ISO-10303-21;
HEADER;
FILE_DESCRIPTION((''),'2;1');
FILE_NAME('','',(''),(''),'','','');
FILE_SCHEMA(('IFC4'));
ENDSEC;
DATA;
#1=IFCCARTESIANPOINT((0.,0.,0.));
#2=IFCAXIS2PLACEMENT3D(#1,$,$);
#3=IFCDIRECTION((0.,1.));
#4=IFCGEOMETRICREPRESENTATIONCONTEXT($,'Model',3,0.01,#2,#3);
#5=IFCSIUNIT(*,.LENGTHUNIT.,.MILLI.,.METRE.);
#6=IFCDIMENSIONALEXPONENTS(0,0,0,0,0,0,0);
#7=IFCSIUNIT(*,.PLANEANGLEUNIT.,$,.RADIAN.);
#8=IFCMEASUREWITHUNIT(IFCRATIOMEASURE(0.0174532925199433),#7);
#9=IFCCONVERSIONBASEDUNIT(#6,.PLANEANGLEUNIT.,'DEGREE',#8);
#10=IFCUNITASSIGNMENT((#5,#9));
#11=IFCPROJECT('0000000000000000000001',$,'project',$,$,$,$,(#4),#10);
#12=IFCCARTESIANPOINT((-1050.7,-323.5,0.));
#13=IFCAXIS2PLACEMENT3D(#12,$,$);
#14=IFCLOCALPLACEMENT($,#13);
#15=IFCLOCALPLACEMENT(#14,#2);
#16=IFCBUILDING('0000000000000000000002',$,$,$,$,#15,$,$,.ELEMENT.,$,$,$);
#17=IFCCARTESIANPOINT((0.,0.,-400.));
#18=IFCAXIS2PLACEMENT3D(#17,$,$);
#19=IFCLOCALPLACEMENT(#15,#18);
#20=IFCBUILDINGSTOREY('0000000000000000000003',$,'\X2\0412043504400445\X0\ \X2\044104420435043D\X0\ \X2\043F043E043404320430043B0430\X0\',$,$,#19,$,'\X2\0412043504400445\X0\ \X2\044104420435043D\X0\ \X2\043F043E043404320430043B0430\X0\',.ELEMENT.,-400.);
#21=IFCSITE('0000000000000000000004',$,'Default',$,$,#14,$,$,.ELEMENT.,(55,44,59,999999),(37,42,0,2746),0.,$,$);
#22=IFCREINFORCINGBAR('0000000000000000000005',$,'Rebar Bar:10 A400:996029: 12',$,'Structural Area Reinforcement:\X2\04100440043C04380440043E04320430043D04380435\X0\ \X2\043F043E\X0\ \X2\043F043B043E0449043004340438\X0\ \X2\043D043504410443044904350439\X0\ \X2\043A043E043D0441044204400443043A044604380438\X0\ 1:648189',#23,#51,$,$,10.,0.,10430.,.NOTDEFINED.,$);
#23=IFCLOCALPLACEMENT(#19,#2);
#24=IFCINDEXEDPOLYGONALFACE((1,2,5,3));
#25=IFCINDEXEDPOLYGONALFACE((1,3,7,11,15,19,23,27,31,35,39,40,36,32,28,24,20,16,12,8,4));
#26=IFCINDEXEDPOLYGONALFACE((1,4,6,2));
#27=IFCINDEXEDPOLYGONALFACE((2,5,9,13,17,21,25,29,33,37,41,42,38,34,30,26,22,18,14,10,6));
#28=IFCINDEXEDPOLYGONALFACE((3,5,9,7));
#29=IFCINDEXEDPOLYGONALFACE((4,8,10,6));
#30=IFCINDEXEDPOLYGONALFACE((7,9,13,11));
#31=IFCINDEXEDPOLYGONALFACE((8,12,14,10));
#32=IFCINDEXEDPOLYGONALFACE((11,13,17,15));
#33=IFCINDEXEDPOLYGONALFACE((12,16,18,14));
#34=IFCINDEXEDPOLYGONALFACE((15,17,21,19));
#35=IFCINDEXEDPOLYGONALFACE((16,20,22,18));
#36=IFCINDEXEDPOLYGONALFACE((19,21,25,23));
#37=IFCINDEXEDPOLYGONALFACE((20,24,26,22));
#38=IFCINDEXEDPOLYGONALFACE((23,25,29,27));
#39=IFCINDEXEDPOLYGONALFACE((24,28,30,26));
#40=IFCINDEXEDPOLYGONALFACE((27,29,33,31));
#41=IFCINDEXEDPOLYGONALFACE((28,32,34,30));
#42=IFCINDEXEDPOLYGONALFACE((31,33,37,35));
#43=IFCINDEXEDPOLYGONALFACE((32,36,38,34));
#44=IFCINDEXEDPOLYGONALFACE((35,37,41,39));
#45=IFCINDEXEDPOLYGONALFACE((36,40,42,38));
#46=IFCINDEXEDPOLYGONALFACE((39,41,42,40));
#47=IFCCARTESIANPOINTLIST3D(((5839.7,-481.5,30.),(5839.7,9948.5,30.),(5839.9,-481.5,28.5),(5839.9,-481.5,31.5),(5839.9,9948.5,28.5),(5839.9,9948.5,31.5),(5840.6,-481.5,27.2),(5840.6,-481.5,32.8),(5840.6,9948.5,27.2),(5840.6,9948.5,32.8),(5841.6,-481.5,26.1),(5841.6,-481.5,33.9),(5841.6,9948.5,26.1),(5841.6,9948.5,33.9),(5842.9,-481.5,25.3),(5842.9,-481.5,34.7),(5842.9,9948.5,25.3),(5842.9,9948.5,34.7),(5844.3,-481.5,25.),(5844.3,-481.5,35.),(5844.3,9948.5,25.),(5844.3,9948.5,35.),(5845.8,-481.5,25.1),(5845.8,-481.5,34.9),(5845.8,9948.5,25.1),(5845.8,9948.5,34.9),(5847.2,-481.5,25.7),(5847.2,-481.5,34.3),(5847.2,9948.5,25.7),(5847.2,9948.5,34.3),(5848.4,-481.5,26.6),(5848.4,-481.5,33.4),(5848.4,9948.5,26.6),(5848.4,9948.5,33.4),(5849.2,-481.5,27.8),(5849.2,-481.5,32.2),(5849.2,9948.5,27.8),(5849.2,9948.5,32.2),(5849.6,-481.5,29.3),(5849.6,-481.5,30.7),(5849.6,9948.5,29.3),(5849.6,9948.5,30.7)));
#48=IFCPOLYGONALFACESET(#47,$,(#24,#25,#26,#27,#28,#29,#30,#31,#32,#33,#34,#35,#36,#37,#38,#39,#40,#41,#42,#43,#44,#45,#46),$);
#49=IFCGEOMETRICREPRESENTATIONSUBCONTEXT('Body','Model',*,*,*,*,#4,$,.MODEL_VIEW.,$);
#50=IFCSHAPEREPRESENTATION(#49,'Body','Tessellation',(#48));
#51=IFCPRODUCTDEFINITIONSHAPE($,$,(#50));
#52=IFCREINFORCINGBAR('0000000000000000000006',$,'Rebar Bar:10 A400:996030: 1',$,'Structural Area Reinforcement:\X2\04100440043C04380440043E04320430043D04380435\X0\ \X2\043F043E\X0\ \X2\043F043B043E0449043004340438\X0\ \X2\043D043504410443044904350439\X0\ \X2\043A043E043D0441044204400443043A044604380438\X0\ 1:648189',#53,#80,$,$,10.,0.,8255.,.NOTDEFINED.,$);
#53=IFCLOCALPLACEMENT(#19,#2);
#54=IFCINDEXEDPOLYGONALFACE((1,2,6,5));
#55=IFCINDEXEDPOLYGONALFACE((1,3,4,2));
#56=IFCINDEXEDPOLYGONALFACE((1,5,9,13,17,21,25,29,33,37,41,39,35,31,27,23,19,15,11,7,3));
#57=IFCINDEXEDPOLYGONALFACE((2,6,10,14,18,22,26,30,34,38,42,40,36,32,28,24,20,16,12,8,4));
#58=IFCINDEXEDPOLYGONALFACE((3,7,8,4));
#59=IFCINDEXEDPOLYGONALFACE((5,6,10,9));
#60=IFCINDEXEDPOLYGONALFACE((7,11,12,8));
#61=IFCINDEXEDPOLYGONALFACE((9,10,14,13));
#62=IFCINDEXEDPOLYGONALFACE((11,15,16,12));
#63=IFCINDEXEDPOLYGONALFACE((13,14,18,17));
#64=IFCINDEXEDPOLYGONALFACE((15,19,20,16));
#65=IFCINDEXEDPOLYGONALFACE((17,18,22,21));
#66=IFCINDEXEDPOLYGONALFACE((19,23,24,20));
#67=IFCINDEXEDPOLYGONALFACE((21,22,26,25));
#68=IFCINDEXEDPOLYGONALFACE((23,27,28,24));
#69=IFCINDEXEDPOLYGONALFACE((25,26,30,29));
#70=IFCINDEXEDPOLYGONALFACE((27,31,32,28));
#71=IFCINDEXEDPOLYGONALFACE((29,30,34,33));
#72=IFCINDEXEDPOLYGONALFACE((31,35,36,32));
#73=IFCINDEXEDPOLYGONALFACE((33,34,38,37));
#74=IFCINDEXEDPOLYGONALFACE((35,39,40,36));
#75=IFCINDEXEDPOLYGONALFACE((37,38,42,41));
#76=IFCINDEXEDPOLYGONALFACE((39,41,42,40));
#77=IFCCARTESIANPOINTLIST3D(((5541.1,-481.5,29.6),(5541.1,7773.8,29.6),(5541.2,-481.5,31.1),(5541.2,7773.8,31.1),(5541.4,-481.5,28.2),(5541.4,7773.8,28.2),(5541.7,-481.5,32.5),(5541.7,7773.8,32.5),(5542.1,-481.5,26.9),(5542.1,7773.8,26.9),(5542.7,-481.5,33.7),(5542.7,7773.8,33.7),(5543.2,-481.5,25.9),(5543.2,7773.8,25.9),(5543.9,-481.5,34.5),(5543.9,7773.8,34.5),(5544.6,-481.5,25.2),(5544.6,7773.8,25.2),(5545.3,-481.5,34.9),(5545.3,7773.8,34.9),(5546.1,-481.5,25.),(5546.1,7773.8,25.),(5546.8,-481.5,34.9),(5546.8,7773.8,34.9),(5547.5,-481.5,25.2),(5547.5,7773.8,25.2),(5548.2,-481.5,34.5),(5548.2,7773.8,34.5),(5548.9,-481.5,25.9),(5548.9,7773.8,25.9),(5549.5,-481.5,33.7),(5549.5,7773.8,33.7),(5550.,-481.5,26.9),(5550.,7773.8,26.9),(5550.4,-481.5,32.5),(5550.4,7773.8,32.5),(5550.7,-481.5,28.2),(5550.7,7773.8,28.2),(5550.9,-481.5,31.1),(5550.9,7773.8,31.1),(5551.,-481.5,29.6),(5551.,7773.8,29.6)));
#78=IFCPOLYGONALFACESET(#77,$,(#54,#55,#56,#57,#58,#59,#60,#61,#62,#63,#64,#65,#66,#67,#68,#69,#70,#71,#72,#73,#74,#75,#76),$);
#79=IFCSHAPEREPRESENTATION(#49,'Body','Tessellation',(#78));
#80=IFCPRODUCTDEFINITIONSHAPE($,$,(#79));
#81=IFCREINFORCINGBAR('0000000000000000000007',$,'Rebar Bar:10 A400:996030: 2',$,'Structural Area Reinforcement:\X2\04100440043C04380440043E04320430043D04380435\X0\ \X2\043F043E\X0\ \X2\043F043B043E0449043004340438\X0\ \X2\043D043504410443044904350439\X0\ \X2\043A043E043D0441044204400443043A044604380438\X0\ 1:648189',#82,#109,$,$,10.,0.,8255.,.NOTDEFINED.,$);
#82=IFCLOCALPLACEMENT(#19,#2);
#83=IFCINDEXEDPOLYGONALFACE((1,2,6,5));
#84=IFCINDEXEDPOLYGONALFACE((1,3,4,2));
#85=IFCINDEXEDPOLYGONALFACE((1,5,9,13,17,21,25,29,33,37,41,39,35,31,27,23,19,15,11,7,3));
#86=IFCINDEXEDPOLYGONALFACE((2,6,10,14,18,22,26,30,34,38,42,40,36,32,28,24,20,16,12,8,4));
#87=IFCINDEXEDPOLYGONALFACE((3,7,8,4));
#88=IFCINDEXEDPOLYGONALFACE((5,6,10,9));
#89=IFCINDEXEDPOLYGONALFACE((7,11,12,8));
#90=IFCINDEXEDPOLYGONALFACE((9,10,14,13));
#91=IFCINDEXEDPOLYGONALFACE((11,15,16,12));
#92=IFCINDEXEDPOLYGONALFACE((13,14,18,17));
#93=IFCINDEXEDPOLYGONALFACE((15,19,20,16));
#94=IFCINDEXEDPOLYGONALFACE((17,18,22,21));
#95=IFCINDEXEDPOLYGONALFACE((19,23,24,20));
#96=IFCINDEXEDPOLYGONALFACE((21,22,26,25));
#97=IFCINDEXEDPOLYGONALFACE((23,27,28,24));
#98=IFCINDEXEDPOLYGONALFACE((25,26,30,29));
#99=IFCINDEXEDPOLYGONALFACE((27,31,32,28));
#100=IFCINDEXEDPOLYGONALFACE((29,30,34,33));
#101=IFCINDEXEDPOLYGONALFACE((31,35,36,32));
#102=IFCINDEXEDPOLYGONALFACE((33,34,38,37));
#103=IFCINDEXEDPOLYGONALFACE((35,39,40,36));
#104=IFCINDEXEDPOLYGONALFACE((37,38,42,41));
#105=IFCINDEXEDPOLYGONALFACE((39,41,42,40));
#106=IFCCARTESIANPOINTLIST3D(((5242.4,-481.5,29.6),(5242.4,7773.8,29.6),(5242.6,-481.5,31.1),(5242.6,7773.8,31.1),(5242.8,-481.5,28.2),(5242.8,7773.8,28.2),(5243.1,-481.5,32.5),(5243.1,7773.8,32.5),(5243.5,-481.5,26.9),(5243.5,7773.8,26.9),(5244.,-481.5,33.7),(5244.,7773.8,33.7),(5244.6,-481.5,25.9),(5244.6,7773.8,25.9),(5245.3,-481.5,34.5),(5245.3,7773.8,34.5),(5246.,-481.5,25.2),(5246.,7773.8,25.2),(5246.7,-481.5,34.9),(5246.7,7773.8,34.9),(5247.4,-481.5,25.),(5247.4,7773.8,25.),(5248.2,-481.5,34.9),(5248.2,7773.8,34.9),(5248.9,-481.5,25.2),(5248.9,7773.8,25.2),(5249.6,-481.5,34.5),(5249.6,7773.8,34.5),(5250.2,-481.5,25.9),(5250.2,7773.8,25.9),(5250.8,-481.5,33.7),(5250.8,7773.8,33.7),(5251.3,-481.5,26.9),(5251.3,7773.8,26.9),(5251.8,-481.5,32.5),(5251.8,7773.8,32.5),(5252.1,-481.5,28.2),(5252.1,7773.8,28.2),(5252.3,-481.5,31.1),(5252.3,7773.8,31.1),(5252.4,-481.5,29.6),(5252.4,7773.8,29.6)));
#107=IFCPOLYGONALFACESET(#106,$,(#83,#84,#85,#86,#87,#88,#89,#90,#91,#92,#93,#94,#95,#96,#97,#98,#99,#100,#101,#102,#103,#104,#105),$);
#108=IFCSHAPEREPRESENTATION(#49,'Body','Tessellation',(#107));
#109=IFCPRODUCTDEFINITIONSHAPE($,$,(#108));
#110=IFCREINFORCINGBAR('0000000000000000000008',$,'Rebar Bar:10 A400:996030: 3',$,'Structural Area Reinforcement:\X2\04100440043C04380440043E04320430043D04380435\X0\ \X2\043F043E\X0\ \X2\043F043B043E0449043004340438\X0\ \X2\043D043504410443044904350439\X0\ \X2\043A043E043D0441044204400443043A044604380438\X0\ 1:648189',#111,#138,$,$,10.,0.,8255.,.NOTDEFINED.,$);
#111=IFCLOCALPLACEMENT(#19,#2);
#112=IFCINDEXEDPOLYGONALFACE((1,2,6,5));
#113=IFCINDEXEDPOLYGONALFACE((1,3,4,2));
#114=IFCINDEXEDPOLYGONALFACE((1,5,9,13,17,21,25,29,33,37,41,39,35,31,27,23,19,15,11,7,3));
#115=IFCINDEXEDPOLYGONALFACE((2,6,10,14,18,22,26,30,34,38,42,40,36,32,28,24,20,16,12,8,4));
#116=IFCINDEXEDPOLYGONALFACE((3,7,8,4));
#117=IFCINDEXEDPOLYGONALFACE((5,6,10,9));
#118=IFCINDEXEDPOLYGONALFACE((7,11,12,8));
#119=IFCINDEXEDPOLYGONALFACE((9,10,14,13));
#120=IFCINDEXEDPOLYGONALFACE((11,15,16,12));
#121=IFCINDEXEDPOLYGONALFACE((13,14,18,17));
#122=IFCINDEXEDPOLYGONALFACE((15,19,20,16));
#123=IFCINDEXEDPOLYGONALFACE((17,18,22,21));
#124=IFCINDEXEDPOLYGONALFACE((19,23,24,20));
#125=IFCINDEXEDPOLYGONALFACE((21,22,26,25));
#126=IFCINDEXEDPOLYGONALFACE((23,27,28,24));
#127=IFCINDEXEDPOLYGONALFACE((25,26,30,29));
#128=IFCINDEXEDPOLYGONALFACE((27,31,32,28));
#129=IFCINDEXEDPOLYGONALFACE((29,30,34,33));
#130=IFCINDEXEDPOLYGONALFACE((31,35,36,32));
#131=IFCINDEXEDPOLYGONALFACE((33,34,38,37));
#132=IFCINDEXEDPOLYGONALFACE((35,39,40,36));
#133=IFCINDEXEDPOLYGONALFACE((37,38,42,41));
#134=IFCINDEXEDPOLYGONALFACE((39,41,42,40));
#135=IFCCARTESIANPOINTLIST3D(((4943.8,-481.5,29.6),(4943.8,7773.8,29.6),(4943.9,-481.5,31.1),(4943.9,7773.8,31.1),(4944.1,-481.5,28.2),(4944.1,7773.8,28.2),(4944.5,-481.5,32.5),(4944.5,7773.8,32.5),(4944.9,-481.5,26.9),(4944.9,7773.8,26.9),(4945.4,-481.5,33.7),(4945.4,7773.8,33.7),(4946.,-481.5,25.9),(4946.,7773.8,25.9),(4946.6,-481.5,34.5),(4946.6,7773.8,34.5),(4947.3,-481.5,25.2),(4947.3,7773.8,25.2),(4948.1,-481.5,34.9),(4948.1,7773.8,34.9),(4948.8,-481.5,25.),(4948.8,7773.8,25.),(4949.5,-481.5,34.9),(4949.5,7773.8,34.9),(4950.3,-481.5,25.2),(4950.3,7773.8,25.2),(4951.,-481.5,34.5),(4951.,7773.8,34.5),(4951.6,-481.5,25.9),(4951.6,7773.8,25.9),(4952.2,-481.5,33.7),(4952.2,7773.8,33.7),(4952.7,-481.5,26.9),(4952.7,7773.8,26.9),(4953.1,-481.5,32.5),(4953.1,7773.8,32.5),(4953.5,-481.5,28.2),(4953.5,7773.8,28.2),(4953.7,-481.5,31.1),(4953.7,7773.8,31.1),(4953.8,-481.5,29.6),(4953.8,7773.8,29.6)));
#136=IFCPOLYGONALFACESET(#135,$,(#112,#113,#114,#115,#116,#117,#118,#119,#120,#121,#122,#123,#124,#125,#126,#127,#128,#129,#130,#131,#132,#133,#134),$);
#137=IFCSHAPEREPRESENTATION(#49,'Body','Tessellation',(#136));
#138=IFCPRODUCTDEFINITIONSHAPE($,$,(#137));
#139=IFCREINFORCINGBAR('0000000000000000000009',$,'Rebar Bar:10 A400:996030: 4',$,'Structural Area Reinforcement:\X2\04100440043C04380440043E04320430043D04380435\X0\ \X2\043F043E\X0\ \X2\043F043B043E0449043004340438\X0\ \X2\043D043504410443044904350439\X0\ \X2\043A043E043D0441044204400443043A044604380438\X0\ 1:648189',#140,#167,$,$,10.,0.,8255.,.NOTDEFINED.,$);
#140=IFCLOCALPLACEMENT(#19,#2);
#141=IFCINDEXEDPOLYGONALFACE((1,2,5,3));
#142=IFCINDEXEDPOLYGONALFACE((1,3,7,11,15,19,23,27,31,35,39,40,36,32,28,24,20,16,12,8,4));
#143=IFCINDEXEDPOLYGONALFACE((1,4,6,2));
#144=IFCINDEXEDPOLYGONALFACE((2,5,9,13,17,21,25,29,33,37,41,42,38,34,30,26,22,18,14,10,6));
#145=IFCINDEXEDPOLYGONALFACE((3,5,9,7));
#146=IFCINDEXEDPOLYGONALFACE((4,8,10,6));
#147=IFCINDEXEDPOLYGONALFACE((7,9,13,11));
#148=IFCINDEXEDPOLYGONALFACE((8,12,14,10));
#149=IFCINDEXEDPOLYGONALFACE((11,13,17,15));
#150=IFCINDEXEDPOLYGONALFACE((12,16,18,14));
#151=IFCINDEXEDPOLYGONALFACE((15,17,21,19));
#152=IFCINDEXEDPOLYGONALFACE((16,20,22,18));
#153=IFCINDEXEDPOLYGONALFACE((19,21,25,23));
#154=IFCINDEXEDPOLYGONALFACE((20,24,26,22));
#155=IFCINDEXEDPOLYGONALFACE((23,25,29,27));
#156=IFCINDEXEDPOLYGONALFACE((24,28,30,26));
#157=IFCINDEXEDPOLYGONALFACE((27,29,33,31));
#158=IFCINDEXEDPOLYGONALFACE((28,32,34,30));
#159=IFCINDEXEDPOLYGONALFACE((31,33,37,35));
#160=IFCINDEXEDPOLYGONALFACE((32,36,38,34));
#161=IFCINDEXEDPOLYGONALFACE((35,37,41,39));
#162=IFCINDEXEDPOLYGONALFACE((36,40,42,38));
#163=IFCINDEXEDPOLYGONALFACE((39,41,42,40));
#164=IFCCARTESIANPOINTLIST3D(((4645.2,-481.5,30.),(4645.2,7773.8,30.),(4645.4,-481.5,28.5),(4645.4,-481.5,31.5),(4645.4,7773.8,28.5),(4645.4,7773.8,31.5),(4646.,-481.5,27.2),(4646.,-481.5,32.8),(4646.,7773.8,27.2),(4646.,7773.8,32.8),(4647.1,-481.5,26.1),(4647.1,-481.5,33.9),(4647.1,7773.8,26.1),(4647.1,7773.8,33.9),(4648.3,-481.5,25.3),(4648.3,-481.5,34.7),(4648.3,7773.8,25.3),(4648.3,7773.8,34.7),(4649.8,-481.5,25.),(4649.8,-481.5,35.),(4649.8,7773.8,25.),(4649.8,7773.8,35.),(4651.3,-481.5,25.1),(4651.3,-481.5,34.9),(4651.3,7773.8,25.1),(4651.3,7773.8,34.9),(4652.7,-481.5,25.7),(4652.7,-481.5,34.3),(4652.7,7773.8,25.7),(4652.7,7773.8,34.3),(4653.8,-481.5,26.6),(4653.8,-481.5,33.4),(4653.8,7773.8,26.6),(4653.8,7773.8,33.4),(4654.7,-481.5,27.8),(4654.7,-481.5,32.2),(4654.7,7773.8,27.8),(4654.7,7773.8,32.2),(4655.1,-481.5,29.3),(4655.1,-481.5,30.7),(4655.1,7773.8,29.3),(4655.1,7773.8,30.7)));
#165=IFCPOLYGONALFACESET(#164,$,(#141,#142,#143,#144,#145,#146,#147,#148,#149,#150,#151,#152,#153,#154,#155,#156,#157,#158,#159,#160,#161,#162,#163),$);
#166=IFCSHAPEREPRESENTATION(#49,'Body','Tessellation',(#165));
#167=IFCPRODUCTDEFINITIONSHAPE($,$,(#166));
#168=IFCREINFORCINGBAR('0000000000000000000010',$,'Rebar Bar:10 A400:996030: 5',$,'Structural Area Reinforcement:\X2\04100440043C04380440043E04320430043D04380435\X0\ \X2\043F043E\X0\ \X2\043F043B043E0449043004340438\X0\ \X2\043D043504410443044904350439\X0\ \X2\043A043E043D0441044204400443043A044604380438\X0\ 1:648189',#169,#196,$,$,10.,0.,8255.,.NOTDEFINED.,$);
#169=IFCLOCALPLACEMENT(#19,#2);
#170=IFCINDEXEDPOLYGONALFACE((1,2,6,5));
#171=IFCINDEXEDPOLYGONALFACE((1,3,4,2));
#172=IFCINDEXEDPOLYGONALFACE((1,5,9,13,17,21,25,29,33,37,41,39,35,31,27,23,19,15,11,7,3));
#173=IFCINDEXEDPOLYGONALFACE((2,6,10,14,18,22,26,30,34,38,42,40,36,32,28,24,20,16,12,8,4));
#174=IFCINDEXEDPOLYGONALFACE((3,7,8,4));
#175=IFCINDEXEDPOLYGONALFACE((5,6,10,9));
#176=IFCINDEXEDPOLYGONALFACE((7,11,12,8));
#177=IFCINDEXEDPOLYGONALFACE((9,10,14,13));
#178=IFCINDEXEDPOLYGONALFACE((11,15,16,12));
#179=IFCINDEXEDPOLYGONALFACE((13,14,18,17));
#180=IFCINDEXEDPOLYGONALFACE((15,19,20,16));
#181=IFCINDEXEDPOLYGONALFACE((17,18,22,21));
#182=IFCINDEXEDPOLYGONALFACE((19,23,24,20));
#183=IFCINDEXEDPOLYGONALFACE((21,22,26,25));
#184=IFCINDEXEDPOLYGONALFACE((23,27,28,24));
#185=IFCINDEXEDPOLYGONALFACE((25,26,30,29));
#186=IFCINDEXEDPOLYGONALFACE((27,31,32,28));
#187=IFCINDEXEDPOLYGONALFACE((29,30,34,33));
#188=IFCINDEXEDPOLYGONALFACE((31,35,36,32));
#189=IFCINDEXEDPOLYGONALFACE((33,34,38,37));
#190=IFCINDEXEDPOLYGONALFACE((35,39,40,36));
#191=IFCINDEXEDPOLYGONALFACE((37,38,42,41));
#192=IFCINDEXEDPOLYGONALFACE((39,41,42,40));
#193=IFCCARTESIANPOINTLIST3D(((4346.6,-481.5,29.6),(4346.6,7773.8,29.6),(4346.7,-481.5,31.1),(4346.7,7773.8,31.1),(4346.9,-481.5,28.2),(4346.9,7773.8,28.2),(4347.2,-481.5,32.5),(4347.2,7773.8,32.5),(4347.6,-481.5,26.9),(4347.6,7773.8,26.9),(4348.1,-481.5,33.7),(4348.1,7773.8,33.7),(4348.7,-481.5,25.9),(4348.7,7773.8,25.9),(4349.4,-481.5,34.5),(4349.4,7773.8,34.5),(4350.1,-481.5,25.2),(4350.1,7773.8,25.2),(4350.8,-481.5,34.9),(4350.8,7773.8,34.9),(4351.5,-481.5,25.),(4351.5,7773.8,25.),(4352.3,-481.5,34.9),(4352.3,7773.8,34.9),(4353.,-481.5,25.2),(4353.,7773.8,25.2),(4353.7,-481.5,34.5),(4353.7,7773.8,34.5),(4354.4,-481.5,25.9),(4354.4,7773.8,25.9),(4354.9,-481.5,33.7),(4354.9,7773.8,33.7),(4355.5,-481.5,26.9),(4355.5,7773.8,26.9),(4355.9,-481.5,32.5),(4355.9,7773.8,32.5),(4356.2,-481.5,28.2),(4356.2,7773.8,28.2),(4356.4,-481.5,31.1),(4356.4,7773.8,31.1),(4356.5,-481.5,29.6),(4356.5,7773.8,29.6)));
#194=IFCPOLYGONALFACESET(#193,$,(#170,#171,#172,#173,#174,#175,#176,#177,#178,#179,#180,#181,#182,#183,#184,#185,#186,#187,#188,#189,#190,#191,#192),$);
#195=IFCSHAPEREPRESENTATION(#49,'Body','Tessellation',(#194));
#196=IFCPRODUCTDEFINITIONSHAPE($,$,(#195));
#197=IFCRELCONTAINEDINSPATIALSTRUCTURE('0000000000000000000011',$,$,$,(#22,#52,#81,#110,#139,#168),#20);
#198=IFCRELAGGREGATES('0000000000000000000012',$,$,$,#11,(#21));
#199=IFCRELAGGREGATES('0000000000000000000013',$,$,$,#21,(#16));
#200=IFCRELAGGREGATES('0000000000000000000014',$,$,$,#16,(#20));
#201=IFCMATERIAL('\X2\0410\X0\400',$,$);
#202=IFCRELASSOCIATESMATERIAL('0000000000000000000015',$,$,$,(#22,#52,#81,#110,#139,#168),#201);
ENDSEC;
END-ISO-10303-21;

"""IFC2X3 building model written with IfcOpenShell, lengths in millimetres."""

from ifc_helpers import new_model, entity, si_unit, converted_unit, direction, frame, origin, place, context, subcontext, project, spatial, material, element, save


model = new_model("IFC2X3")

# Units and contexts
model_context = context("Model", 3, precision=0.01, world=origin(), true_north=direction((0.0, 1.0)))
body_context = subcontext(model_context, "Body", "Model", "MODEL_VIEW")
ifc_project = project(units=[si_unit("LENGTHUNIT", "METRE", prefix="MILLI"), converted_unit("PLANEANGLEUNIT", "DEGREE", entity("IfcRatioMeasure", 0.0174532925199433), si_unit("PLANEANGLEUNIT", "RADIAN"), dimensions=[0, 0, 0, 0, 0, 0, 0])], contexts=[model_context])

# Site, building, storey
site_placement = place(None, frame((-1050.7, -323.5, 0.0)))
site = spatial("IfcSite", under=ifc_project, at=site_placement, Name="Default", CompositionType="ELEMENT", RefLatitude=(55, 44, 59, 999999), RefLongitude=(37, 42, 0, 2746), RefElevation=0.0)
building_placement = place(site_placement, origin())
building = spatial("IfcBuilding", under=site, at=building_placement, CompositionType="ELEMENT")
storey_placement = place(building_placement, frame((0.0, 0.0, -400.0)))
storey = spatial("IfcBuildingStorey", under=building, at=storey_placement, Name="Верх стен подвала", LongName="Верх стен подвала", CompositionType="ELEMENT", Elevation=-400.0)

# Reinforcing bars
ifc_material = material(Name="А400")
reinforcing_bar_1_placement = place(storey_placement, origin())
element("IfcReinforcingBar", 1, at=reinforcing_bar_1_placement, inside=storey, material=ifc_material, Name="Rebar Bar:10 A400:996029: 12", ObjectType="Structural Area Reinforcement:Армирование по площади несущей конструкции 1:648189", BarLength=10430.0, BarRole="NOTDEFINED", CrossSectionArea=0.0, NominalDiameter=10.0, context=body_context, shape_type="AdvancedSweptSolid", body=[
    entity("IfcSweptDiskSolid", entity("IfcCompositeCurve", [entity("IfcCompositeCurveSegment", "CONTINUOUS", True, entity("IfcPolyline", [entity("IfcCartesianPoint", [5844.7, 9948.5, 30.0]), entity("IfcCartesianPoint", [5844.7, -481.5, 30.0])]))], False), 5.0, None, 0.0, 1.0),
])
reinforcing_bar_2_placement = place(storey_placement, origin())
element("IfcReinforcingBar", 2, at=reinforcing_bar_2_placement, inside=storey, material=ifc_material, Name="Rebar Bar:10 A400:996030: 1", ObjectType="Structural Area Reinforcement:Армирование по площади несущей конструкции 1:648189", BarLength=8255.0, BarRole="NOTDEFINED", CrossSectionArea=0.0, NominalDiameter=10.0, context=body_context, shape_type="AdvancedSweptSolid", body=[
    entity("IfcSweptDiskSolid", entity("IfcCompositeCurve", [entity("IfcCompositeCurveSegment", "CONTINUOUS", True, entity("IfcPolyline", [entity("IfcCartesianPoint", [5546.1, 7773.8, 30.0]), entity("IfcCartesianPoint", [5546.1, -481.5, 30.0])]))], False), 5.0, None, 0.0, 1.0),
])
reinforcing_bar_3_placement = place(storey_placement, origin())
element("IfcReinforcingBar", 3, at=reinforcing_bar_3_placement, inside=storey, material=ifc_material, Name="Rebar Bar:10 A400:996030: 2", ObjectType="Structural Area Reinforcement:Армирование по площади несущей конструкции 1:648189", BarLength=8255.0, BarRole="NOTDEFINED", CrossSectionArea=0.0, NominalDiameter=10.0, context=body_context, shape_type="AdvancedSweptSolid", body=[
    entity("IfcSweptDiskSolid", entity("IfcCompositeCurve", [entity("IfcCompositeCurveSegment", "CONTINUOUS", True, entity("IfcPolyline", [entity("IfcCartesianPoint", [5247.4, 7773.8, 30.0]), entity("IfcCartesianPoint", [5247.4, -481.5, 30.0])]))], False), 5.0, None, 0.0, 1.0),
])
reinforcing_bar_4_placement = place(storey_placement, origin())
element("IfcReinforcingBar", 4, at=reinforcing_bar_4_placement, inside=storey, material=ifc_material, Name="Rebar Bar:10 A400:996030: 3", ObjectType="Structural Area Reinforcement:Армирование по площади несущей конструкции 1:648189", BarLength=8255.0, BarRole="NOTDEFINED", CrossSectionArea=0.0, NominalDiameter=10.0, context=body_context, shape_type="AdvancedSweptSolid", body=[
    entity("IfcSweptDiskSolid", entity("IfcCompositeCurve", [entity("IfcCompositeCurveSegment", "CONTINUOUS", True, entity("IfcPolyline", [entity("IfcCartesianPoint", [4948.8, 7773.8, 30.0]), entity("IfcCartesianPoint", [4948.8, -481.5, 30.0])]))], False), 5.0, None, 0.0, 1.0),
])
reinforcing_bar_5_placement = place(storey_placement, origin())
element("IfcReinforcingBar", 5, at=reinforcing_bar_5_placement, inside=storey, material=ifc_material, Name="Rebar Bar:10 A400:996030: 4", ObjectType="Structural Area Reinforcement:Армирование по площади несущей конструкции 1:648189", BarLength=8255.0, BarRole="NOTDEFINED", CrossSectionArea=0.0, NominalDiameter=10.0, context=body_context, shape_type="AdvancedSweptSolid", body=[
    entity("IfcSweptDiskSolid", entity("IfcCompositeCurve", [entity("IfcCompositeCurveSegment", "CONTINUOUS", True, entity("IfcPolyline", [entity("IfcCartesianPoint", [4650.2, 7773.8, 30.0]), entity("IfcCartesianPoint", [4650.2, -481.5, 30.0])]))], False), 5.0, None, 0.0, 1.0),
])
reinforcing_bar_6_placement = place(storey_placement, origin())
element("IfcReinforcingBar", 6, at=reinforcing_bar_6_placement, inside=storey, material=ifc_material, Name="Rebar Bar:10 A400:996030: 5", ObjectType="Structural Area Reinforcement:Армирование по площади несущей конструкции 1:648189", BarLength=8255.0, BarRole="NOTDEFINED", CrossSectionArea=0.0, NominalDiameter=10.0, context=body_context, shape_type="AdvancedSweptSolid", body=[
    entity("IfcSweptDiskSolid", entity("IfcCompositeCurve", [entity("IfcCompositeCurveSegment", "CONTINUOUS", True, entity("IfcPolyline", [entity("IfcCartesianPoint", [4351.5, 7773.8, 30.0]), entity("IfcCartesianPoint", [4351.5, -481.5, 30.0])]))], False), 5.0, None, 0.0, 1.0),
])

save(model, "model.ifc")
